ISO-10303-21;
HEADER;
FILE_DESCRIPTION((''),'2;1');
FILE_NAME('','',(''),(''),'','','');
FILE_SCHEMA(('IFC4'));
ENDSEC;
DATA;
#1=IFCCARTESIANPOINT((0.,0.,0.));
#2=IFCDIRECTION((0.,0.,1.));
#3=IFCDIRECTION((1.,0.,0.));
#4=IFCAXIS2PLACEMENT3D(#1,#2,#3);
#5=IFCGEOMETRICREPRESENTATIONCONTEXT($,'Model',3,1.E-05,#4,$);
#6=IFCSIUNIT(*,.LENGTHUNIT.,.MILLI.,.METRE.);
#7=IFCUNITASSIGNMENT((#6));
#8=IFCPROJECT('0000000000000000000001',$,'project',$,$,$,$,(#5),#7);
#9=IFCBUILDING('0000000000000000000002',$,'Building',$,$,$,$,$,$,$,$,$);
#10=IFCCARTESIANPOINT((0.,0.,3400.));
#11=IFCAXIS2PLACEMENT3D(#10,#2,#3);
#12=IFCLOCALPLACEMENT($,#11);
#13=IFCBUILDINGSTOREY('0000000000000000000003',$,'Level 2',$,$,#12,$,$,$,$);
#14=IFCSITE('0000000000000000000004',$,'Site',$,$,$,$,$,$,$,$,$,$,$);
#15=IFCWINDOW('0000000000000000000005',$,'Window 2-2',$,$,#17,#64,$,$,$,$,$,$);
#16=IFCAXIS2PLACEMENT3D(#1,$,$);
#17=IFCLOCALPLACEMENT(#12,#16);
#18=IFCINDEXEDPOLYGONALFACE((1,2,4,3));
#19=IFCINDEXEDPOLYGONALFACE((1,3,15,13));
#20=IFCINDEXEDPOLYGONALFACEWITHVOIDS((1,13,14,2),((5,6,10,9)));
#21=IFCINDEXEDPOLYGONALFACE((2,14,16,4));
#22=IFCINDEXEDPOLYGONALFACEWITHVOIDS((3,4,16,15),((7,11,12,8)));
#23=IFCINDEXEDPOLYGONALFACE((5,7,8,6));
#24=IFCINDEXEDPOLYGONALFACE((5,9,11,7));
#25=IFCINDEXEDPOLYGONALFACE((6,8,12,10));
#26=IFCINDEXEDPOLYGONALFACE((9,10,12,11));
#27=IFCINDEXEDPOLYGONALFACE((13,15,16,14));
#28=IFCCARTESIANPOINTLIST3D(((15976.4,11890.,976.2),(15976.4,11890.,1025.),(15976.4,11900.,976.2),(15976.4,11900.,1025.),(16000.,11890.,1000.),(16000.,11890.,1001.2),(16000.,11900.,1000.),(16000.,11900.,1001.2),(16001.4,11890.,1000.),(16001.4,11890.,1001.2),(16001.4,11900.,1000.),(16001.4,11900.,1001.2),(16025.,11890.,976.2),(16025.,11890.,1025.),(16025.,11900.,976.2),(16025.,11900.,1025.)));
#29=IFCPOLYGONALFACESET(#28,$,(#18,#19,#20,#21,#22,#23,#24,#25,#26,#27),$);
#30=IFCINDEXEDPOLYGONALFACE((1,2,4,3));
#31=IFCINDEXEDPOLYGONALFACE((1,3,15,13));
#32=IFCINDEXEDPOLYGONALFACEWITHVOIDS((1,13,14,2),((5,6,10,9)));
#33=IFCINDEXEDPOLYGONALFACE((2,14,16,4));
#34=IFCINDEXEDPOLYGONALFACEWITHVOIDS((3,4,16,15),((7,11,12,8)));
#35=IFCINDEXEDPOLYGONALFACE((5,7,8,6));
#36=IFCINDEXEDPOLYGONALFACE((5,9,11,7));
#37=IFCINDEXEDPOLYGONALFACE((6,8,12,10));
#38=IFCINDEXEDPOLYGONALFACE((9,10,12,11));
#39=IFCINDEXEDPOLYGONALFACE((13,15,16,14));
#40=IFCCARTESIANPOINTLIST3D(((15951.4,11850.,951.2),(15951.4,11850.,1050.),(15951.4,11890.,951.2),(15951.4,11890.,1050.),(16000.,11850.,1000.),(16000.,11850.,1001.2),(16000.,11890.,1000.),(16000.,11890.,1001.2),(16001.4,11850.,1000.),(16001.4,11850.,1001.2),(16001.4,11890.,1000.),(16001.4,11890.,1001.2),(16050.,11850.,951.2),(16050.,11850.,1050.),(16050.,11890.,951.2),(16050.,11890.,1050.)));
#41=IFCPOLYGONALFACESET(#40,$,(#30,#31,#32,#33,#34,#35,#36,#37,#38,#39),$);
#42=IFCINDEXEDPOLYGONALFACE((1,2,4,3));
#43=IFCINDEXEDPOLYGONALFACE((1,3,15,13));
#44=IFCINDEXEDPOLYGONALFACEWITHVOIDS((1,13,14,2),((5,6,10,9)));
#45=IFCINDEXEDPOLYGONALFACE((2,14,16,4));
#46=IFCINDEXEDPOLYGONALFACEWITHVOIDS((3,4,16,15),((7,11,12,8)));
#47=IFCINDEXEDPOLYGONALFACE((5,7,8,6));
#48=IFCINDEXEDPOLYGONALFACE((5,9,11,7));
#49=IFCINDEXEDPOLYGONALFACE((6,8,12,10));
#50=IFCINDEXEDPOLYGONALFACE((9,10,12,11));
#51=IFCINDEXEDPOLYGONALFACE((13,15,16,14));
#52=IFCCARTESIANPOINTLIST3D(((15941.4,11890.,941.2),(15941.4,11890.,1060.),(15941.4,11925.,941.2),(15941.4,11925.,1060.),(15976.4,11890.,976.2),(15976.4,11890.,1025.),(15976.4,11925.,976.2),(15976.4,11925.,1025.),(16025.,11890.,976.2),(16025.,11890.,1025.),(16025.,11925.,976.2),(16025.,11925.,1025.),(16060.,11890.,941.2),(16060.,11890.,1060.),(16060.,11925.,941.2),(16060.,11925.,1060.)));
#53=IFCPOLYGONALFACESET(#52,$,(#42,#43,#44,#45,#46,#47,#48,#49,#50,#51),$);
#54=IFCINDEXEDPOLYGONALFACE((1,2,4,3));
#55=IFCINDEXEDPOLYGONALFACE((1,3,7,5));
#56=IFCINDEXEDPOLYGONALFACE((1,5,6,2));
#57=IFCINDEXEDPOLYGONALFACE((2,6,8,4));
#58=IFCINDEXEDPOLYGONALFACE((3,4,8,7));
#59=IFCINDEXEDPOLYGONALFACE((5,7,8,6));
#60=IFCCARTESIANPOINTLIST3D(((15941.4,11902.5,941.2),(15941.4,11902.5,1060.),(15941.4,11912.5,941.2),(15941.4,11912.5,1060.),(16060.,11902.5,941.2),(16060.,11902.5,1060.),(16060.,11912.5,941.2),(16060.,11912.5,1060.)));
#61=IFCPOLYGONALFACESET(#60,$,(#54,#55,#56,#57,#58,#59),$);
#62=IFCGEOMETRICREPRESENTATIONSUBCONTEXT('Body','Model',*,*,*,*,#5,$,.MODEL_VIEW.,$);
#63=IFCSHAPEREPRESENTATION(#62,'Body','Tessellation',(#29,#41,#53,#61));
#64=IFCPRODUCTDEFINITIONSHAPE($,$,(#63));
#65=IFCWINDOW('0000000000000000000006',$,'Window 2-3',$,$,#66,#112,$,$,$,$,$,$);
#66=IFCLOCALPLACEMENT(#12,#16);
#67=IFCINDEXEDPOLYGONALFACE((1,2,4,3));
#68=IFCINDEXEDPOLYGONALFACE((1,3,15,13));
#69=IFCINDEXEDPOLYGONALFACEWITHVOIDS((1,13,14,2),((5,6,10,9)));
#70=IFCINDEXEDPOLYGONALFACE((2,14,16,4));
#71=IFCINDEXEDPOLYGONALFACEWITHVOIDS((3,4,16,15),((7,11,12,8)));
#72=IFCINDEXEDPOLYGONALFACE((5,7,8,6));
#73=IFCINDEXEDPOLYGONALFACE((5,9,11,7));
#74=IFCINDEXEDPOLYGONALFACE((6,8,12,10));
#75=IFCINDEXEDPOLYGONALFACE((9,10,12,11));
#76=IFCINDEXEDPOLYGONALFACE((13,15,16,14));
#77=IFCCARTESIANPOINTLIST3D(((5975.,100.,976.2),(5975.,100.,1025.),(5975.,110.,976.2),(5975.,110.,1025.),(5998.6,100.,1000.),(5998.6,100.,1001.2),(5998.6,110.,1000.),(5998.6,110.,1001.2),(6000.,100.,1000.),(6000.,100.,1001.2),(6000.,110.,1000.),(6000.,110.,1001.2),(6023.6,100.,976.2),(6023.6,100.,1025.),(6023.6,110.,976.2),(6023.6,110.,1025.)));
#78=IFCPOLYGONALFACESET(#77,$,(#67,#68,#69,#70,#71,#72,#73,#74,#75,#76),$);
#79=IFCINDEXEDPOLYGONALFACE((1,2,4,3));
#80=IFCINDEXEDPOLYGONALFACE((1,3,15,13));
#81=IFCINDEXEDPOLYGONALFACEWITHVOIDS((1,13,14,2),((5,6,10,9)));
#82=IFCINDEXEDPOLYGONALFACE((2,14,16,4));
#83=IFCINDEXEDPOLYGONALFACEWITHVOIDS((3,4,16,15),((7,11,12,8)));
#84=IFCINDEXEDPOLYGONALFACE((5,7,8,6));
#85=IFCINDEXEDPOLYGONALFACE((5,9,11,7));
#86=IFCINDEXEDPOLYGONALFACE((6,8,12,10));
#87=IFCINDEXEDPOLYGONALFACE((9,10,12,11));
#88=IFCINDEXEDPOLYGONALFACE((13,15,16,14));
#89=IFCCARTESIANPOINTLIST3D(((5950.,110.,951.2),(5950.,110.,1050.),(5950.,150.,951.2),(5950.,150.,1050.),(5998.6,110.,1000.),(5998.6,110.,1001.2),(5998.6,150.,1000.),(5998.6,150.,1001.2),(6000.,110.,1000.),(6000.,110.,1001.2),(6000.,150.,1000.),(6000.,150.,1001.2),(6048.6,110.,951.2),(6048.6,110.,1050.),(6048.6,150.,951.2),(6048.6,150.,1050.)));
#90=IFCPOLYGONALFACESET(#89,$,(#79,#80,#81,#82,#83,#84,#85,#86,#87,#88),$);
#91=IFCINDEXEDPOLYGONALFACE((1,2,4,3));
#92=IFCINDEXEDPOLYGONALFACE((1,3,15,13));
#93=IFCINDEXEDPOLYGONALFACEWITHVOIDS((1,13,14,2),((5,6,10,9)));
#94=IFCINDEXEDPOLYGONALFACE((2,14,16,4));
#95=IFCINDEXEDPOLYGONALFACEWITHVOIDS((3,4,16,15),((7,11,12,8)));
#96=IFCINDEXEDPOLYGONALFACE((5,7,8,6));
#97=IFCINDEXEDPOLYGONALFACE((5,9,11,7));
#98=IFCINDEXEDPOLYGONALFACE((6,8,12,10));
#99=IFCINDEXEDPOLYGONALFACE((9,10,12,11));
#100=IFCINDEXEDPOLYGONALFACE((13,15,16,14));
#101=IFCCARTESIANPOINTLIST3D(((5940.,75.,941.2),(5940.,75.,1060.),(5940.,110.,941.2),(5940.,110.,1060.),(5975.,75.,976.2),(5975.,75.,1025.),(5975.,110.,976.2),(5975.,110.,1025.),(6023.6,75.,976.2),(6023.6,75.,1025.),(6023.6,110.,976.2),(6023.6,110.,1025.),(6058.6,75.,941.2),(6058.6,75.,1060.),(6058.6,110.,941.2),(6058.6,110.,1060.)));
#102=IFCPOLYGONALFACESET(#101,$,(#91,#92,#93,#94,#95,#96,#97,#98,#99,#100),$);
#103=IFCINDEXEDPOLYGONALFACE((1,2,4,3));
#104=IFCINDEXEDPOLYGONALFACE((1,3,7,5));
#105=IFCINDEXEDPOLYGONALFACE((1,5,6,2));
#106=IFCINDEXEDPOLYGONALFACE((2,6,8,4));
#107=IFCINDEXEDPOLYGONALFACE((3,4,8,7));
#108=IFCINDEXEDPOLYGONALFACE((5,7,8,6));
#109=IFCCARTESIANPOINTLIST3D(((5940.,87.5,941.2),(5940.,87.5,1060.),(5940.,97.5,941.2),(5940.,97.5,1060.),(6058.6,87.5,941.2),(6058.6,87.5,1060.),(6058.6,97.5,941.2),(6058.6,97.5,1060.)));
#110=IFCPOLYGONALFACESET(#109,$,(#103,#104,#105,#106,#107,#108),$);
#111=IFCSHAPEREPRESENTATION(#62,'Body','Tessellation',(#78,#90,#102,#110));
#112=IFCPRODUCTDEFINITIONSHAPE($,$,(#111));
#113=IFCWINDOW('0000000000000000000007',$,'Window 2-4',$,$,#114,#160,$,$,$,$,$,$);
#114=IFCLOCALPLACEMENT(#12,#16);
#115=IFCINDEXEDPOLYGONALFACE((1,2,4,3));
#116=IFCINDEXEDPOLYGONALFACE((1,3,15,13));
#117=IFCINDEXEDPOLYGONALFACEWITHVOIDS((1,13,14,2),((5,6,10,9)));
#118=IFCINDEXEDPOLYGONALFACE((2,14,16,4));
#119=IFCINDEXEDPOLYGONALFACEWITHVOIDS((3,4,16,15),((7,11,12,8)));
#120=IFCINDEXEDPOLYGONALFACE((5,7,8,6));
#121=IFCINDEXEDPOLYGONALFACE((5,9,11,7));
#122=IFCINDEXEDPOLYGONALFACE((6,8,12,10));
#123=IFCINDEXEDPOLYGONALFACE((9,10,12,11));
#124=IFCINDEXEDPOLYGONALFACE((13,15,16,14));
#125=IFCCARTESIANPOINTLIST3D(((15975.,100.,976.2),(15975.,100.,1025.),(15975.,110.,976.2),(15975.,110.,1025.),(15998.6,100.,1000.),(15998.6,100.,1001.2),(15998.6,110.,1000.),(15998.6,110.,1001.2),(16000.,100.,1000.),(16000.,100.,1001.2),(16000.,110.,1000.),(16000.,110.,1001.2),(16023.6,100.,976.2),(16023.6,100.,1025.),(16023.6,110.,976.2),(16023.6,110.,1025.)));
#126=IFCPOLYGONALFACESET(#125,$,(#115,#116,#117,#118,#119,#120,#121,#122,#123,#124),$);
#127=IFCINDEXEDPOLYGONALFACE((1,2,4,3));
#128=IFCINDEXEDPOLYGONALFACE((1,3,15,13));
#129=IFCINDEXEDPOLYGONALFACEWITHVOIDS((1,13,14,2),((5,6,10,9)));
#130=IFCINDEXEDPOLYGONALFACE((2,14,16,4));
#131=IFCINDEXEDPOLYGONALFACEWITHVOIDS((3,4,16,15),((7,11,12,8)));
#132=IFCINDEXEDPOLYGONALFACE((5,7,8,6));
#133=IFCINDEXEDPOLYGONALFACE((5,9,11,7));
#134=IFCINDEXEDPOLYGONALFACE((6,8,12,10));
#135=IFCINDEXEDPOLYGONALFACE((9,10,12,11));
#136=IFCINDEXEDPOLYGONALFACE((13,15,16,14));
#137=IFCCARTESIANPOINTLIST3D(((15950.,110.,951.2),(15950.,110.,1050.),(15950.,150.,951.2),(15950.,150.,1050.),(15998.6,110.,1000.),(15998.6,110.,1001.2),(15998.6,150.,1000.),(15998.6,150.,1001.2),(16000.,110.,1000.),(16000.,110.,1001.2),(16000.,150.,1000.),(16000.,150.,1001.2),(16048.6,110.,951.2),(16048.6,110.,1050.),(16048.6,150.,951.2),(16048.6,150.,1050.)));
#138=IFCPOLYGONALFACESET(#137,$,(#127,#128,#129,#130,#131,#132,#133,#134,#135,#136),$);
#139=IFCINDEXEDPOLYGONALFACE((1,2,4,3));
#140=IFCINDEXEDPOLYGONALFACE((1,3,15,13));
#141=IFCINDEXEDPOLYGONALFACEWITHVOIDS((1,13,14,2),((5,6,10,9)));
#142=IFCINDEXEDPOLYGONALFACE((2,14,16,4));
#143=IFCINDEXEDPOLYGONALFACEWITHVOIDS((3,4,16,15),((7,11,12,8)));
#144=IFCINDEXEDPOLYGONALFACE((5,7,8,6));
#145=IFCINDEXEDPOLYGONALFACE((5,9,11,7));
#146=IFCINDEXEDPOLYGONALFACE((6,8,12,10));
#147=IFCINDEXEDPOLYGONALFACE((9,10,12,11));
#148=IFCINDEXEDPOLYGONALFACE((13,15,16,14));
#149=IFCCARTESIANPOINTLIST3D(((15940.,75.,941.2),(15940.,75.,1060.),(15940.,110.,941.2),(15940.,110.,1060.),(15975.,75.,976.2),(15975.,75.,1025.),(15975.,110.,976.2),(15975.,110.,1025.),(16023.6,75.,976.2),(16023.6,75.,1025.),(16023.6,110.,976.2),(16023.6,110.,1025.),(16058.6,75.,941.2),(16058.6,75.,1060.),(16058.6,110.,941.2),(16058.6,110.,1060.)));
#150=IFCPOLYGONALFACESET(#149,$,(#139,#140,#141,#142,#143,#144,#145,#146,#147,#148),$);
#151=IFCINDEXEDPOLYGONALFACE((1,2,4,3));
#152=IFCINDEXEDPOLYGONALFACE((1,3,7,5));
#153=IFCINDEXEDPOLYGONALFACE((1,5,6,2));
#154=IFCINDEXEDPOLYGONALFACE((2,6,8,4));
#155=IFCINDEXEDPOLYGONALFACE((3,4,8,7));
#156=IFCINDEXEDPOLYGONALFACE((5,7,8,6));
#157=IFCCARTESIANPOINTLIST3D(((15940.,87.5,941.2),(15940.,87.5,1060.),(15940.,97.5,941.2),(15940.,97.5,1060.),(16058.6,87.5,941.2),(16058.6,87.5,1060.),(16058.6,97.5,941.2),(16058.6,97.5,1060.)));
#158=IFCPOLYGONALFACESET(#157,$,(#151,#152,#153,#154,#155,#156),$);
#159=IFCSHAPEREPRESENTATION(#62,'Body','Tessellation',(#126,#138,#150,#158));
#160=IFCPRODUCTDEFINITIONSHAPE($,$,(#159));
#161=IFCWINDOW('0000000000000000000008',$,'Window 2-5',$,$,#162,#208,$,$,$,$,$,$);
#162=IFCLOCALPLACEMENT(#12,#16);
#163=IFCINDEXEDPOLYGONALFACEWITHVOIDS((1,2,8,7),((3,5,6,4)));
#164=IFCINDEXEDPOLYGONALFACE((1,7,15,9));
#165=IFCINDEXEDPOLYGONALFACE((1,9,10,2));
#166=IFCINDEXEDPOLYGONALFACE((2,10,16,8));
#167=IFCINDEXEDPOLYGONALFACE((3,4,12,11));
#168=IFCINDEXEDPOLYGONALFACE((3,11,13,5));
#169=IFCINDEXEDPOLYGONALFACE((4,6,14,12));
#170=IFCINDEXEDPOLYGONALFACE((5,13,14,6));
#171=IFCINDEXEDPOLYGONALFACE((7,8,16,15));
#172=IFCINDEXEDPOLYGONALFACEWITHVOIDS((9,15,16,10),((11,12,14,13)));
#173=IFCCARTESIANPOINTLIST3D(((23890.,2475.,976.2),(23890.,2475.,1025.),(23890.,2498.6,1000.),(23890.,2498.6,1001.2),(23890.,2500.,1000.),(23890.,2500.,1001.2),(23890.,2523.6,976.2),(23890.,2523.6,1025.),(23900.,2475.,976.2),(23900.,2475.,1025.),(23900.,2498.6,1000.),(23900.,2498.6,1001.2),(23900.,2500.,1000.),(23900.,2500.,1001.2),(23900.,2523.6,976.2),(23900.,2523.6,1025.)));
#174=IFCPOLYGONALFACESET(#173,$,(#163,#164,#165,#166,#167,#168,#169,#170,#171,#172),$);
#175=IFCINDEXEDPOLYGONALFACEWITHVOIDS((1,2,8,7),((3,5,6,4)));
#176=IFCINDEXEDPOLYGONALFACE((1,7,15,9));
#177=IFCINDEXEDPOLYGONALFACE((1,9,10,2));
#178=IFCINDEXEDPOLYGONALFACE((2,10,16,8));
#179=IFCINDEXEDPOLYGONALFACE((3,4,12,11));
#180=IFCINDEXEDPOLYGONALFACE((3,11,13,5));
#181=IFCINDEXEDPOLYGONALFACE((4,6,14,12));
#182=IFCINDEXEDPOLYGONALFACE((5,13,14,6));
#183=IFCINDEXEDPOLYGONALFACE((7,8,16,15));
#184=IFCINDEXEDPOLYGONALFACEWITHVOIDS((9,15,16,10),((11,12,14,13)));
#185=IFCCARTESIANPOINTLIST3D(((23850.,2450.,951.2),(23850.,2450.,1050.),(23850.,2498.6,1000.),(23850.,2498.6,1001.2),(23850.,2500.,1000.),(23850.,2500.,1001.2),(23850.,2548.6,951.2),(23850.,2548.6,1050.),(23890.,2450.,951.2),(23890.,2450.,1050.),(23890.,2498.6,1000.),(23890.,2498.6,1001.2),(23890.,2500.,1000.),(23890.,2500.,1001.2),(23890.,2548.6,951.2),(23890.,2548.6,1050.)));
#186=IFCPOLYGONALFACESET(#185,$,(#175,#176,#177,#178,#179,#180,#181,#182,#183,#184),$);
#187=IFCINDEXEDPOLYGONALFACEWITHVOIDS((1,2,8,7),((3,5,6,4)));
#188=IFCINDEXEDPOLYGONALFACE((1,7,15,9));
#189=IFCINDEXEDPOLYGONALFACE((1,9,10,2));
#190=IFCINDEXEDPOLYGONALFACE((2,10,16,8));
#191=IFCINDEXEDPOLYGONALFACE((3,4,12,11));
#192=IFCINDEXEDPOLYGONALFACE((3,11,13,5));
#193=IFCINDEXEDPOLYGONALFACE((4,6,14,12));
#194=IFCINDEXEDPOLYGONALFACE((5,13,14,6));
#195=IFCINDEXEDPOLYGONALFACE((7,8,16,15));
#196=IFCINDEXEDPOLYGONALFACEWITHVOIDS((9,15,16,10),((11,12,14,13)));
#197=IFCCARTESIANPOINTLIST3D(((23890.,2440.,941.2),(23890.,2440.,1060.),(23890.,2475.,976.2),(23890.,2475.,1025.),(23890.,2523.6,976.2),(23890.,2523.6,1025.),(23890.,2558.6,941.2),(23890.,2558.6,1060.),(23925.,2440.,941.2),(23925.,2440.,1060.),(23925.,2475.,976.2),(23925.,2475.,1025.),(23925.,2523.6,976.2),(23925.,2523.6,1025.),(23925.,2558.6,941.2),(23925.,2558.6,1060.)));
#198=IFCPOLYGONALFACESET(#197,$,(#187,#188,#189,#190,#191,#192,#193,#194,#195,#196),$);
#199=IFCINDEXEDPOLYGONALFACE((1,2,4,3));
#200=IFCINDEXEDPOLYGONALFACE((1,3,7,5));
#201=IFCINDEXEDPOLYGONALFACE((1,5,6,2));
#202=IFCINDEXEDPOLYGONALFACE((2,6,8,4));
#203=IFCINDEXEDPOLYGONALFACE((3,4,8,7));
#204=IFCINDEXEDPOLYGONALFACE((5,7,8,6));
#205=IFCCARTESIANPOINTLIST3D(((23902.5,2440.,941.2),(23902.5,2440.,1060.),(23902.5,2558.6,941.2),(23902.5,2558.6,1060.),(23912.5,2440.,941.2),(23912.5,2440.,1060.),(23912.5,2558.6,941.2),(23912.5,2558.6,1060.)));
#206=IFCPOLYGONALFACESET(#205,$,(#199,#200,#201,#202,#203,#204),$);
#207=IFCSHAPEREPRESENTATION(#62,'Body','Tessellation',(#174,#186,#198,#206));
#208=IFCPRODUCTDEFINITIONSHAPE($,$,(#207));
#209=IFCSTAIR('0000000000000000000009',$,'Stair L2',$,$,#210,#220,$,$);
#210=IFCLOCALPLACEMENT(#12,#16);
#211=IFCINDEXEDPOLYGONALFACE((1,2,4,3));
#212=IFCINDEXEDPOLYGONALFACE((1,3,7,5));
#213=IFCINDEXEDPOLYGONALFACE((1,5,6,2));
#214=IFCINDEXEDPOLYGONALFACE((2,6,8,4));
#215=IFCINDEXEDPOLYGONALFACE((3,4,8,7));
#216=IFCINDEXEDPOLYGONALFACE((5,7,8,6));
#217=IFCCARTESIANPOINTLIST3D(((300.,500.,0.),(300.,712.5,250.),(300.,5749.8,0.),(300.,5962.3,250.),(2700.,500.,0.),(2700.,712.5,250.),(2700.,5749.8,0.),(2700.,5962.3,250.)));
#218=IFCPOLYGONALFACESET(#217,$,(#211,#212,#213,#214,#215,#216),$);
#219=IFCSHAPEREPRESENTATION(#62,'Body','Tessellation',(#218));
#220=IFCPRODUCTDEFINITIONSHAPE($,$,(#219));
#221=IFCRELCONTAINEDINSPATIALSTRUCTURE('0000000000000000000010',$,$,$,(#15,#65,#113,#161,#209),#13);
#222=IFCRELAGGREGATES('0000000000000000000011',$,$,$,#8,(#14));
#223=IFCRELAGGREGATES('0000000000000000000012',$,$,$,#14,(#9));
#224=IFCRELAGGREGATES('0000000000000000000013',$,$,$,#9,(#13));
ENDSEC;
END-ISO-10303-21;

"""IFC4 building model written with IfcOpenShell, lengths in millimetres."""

from ifc_helpers import new_model, si_unit, frame, origin_with_axes, place, context, subcontext, project, spatial, line, indexed_curve, outline, extrude, element, save


model = new_model("IFC4")

# Units and contexts
model_context = context("Model", 3, precision=1e-05, world=origin_with_axes())
body_context = subcontext(model_context, "Body", "Model", "MODEL_VIEW")
ifc_project = project(units=[si_unit("LENGTHUNIT", "METRE", prefix="MILLI")], contexts=[model_context])

# Site, building, storey
site = spatial("IfcSite", under=ifc_project, Name="Site")
building = spatial("IfcBuilding", under=site, Name="Building")
storey_placement = place(None, frame((0.0, 0.0, 3400.0), z_axis=(0.0, 0.0, 1.0), x_axis=(1.0, 0.0, 0.0)))
storey = spatial("IfcBuildingStorey", under=building, at=storey_placement, Name="Level 2")

# Windows
for number, where, z_axis, x_axis, name in (
    (1, (16000.0, 11800.0, 1000.0), (0.0, 0.0, 1.0), (1.0, 0.0, 0.0), "Window 2-2"),
    (2, (6000.0, 200.0, 1000.0), (0.0, 0.0, 1.0), (-1.0, 0.0, 0.0), "Window 2-3"),
    (3, (16000.0, 200.0, 1000.0), (0.0, 0.0, 1.0), (-1.0, 0.0, 0.0), "Window 2-4"),
    (4, (23800.0, 2500.0, 1000.0), (0.0, 0.0, 1.0), (0.0, -1.0, 0.0), "Window 2-5"),
):
    element("IfcWindow", number, at=place(storey_placement, frame(where, z_axis=z_axis, x_axis=x_axis)), inside=storey, Name=name, context=body_context, shape_type="SweptSolid", body=[
        extrude(outline(indexed_curve([(0.0, 0.0), (1.4, 0.0), (1.4, 1.2), (0.0, 1.2)], segments=[line(1, 2, 3, 4, 1)]), holes=[indexed_curve([(25.0, 25.0), (-23.6, 25.0), (-23.6, -23.8), (25.0, -23.8)], segments=[line(1, 2, 3, 4, 1)])]), frame((0.0, 90.0, 0.0), z_axis=(0.0, -1.0, 0.0), x_axis=(1.0, 0.0, 0.0)), (0.0, 0.0, -1.0), 10.0),
        extrude(outline(indexed_curve([(0.0, 0.0), (1.4, 0.0), (1.4, 1.2), (0.0, 1.2)], segments=[line(1, 2, 3, 4, 1)]), holes=[indexed_curve([(50.0, 50.0), (-48.6, 50.0), (-48.6, -48.8), (50.0, -48.8)], segments=[line(1, 2, 3, 4, 1)])]), frame((0.0, 50.0, 0.0), z_axis=(0.0, -1.0, 0.0), x_axis=(1.0, 0.0, 0.0)), (0.0, 0.0, -1.0), 40.0),
        extrude(outline(indexed_curve([(0.0, 0.0), (-48.6, 0.0), (-48.6, -48.8), (0.0, -48.8)], segments=[line(1, 2, 3, 4, 1)]), holes=[indexed_curve([(35.0, 35.0), (-83.6, 35.0), (-83.6, -83.8), (35.0, -83.8)], segments=[line(1, 2, 3, 4, 1)])]), frame((25.0, 90.0, 25.0), z_axis=(0.0, -1.0, 0.0), x_axis=(1.0, 0.0, 0.0)), (0.0, 0.0, -1.0), 35.0),
        extrude(outline(indexed_curve([(35.0, 35.0), (-83.6, 35.0), (-83.6, -83.8), (35.0, -83.8)], segments=[line(1, 2, 3, 4, 1)])), frame((25.0, 102.5, 25.0), z_axis=(0.0, -1.0, 0.0), x_axis=(1.0, 0.0, 0.0)), (0.0, 0.0, -1.0), 10.0),
    ])

# Stair
stair_placement = place(storey_placement, frame((300.0, 500.0, 0.0), z_axis=(0.0, 0.0, 1.0), x_axis=(1.0, 0.0, 0.0)))
element("IfcStair", 5, at=stair_placement, inside=storey, Name="Stair L2", context=body_context, shape_type="SweptSolid", body=[
    extrude(outline(indexed_curve([(0.0, 0.0), (2400.0, 0.0), (2400.0, 5249.8), (0.0, 5249.8), (0.0, 0.0)])), None, (0.0, 0.647648, 0.761939), 328.1),
])

save(model, "model.ifc")
